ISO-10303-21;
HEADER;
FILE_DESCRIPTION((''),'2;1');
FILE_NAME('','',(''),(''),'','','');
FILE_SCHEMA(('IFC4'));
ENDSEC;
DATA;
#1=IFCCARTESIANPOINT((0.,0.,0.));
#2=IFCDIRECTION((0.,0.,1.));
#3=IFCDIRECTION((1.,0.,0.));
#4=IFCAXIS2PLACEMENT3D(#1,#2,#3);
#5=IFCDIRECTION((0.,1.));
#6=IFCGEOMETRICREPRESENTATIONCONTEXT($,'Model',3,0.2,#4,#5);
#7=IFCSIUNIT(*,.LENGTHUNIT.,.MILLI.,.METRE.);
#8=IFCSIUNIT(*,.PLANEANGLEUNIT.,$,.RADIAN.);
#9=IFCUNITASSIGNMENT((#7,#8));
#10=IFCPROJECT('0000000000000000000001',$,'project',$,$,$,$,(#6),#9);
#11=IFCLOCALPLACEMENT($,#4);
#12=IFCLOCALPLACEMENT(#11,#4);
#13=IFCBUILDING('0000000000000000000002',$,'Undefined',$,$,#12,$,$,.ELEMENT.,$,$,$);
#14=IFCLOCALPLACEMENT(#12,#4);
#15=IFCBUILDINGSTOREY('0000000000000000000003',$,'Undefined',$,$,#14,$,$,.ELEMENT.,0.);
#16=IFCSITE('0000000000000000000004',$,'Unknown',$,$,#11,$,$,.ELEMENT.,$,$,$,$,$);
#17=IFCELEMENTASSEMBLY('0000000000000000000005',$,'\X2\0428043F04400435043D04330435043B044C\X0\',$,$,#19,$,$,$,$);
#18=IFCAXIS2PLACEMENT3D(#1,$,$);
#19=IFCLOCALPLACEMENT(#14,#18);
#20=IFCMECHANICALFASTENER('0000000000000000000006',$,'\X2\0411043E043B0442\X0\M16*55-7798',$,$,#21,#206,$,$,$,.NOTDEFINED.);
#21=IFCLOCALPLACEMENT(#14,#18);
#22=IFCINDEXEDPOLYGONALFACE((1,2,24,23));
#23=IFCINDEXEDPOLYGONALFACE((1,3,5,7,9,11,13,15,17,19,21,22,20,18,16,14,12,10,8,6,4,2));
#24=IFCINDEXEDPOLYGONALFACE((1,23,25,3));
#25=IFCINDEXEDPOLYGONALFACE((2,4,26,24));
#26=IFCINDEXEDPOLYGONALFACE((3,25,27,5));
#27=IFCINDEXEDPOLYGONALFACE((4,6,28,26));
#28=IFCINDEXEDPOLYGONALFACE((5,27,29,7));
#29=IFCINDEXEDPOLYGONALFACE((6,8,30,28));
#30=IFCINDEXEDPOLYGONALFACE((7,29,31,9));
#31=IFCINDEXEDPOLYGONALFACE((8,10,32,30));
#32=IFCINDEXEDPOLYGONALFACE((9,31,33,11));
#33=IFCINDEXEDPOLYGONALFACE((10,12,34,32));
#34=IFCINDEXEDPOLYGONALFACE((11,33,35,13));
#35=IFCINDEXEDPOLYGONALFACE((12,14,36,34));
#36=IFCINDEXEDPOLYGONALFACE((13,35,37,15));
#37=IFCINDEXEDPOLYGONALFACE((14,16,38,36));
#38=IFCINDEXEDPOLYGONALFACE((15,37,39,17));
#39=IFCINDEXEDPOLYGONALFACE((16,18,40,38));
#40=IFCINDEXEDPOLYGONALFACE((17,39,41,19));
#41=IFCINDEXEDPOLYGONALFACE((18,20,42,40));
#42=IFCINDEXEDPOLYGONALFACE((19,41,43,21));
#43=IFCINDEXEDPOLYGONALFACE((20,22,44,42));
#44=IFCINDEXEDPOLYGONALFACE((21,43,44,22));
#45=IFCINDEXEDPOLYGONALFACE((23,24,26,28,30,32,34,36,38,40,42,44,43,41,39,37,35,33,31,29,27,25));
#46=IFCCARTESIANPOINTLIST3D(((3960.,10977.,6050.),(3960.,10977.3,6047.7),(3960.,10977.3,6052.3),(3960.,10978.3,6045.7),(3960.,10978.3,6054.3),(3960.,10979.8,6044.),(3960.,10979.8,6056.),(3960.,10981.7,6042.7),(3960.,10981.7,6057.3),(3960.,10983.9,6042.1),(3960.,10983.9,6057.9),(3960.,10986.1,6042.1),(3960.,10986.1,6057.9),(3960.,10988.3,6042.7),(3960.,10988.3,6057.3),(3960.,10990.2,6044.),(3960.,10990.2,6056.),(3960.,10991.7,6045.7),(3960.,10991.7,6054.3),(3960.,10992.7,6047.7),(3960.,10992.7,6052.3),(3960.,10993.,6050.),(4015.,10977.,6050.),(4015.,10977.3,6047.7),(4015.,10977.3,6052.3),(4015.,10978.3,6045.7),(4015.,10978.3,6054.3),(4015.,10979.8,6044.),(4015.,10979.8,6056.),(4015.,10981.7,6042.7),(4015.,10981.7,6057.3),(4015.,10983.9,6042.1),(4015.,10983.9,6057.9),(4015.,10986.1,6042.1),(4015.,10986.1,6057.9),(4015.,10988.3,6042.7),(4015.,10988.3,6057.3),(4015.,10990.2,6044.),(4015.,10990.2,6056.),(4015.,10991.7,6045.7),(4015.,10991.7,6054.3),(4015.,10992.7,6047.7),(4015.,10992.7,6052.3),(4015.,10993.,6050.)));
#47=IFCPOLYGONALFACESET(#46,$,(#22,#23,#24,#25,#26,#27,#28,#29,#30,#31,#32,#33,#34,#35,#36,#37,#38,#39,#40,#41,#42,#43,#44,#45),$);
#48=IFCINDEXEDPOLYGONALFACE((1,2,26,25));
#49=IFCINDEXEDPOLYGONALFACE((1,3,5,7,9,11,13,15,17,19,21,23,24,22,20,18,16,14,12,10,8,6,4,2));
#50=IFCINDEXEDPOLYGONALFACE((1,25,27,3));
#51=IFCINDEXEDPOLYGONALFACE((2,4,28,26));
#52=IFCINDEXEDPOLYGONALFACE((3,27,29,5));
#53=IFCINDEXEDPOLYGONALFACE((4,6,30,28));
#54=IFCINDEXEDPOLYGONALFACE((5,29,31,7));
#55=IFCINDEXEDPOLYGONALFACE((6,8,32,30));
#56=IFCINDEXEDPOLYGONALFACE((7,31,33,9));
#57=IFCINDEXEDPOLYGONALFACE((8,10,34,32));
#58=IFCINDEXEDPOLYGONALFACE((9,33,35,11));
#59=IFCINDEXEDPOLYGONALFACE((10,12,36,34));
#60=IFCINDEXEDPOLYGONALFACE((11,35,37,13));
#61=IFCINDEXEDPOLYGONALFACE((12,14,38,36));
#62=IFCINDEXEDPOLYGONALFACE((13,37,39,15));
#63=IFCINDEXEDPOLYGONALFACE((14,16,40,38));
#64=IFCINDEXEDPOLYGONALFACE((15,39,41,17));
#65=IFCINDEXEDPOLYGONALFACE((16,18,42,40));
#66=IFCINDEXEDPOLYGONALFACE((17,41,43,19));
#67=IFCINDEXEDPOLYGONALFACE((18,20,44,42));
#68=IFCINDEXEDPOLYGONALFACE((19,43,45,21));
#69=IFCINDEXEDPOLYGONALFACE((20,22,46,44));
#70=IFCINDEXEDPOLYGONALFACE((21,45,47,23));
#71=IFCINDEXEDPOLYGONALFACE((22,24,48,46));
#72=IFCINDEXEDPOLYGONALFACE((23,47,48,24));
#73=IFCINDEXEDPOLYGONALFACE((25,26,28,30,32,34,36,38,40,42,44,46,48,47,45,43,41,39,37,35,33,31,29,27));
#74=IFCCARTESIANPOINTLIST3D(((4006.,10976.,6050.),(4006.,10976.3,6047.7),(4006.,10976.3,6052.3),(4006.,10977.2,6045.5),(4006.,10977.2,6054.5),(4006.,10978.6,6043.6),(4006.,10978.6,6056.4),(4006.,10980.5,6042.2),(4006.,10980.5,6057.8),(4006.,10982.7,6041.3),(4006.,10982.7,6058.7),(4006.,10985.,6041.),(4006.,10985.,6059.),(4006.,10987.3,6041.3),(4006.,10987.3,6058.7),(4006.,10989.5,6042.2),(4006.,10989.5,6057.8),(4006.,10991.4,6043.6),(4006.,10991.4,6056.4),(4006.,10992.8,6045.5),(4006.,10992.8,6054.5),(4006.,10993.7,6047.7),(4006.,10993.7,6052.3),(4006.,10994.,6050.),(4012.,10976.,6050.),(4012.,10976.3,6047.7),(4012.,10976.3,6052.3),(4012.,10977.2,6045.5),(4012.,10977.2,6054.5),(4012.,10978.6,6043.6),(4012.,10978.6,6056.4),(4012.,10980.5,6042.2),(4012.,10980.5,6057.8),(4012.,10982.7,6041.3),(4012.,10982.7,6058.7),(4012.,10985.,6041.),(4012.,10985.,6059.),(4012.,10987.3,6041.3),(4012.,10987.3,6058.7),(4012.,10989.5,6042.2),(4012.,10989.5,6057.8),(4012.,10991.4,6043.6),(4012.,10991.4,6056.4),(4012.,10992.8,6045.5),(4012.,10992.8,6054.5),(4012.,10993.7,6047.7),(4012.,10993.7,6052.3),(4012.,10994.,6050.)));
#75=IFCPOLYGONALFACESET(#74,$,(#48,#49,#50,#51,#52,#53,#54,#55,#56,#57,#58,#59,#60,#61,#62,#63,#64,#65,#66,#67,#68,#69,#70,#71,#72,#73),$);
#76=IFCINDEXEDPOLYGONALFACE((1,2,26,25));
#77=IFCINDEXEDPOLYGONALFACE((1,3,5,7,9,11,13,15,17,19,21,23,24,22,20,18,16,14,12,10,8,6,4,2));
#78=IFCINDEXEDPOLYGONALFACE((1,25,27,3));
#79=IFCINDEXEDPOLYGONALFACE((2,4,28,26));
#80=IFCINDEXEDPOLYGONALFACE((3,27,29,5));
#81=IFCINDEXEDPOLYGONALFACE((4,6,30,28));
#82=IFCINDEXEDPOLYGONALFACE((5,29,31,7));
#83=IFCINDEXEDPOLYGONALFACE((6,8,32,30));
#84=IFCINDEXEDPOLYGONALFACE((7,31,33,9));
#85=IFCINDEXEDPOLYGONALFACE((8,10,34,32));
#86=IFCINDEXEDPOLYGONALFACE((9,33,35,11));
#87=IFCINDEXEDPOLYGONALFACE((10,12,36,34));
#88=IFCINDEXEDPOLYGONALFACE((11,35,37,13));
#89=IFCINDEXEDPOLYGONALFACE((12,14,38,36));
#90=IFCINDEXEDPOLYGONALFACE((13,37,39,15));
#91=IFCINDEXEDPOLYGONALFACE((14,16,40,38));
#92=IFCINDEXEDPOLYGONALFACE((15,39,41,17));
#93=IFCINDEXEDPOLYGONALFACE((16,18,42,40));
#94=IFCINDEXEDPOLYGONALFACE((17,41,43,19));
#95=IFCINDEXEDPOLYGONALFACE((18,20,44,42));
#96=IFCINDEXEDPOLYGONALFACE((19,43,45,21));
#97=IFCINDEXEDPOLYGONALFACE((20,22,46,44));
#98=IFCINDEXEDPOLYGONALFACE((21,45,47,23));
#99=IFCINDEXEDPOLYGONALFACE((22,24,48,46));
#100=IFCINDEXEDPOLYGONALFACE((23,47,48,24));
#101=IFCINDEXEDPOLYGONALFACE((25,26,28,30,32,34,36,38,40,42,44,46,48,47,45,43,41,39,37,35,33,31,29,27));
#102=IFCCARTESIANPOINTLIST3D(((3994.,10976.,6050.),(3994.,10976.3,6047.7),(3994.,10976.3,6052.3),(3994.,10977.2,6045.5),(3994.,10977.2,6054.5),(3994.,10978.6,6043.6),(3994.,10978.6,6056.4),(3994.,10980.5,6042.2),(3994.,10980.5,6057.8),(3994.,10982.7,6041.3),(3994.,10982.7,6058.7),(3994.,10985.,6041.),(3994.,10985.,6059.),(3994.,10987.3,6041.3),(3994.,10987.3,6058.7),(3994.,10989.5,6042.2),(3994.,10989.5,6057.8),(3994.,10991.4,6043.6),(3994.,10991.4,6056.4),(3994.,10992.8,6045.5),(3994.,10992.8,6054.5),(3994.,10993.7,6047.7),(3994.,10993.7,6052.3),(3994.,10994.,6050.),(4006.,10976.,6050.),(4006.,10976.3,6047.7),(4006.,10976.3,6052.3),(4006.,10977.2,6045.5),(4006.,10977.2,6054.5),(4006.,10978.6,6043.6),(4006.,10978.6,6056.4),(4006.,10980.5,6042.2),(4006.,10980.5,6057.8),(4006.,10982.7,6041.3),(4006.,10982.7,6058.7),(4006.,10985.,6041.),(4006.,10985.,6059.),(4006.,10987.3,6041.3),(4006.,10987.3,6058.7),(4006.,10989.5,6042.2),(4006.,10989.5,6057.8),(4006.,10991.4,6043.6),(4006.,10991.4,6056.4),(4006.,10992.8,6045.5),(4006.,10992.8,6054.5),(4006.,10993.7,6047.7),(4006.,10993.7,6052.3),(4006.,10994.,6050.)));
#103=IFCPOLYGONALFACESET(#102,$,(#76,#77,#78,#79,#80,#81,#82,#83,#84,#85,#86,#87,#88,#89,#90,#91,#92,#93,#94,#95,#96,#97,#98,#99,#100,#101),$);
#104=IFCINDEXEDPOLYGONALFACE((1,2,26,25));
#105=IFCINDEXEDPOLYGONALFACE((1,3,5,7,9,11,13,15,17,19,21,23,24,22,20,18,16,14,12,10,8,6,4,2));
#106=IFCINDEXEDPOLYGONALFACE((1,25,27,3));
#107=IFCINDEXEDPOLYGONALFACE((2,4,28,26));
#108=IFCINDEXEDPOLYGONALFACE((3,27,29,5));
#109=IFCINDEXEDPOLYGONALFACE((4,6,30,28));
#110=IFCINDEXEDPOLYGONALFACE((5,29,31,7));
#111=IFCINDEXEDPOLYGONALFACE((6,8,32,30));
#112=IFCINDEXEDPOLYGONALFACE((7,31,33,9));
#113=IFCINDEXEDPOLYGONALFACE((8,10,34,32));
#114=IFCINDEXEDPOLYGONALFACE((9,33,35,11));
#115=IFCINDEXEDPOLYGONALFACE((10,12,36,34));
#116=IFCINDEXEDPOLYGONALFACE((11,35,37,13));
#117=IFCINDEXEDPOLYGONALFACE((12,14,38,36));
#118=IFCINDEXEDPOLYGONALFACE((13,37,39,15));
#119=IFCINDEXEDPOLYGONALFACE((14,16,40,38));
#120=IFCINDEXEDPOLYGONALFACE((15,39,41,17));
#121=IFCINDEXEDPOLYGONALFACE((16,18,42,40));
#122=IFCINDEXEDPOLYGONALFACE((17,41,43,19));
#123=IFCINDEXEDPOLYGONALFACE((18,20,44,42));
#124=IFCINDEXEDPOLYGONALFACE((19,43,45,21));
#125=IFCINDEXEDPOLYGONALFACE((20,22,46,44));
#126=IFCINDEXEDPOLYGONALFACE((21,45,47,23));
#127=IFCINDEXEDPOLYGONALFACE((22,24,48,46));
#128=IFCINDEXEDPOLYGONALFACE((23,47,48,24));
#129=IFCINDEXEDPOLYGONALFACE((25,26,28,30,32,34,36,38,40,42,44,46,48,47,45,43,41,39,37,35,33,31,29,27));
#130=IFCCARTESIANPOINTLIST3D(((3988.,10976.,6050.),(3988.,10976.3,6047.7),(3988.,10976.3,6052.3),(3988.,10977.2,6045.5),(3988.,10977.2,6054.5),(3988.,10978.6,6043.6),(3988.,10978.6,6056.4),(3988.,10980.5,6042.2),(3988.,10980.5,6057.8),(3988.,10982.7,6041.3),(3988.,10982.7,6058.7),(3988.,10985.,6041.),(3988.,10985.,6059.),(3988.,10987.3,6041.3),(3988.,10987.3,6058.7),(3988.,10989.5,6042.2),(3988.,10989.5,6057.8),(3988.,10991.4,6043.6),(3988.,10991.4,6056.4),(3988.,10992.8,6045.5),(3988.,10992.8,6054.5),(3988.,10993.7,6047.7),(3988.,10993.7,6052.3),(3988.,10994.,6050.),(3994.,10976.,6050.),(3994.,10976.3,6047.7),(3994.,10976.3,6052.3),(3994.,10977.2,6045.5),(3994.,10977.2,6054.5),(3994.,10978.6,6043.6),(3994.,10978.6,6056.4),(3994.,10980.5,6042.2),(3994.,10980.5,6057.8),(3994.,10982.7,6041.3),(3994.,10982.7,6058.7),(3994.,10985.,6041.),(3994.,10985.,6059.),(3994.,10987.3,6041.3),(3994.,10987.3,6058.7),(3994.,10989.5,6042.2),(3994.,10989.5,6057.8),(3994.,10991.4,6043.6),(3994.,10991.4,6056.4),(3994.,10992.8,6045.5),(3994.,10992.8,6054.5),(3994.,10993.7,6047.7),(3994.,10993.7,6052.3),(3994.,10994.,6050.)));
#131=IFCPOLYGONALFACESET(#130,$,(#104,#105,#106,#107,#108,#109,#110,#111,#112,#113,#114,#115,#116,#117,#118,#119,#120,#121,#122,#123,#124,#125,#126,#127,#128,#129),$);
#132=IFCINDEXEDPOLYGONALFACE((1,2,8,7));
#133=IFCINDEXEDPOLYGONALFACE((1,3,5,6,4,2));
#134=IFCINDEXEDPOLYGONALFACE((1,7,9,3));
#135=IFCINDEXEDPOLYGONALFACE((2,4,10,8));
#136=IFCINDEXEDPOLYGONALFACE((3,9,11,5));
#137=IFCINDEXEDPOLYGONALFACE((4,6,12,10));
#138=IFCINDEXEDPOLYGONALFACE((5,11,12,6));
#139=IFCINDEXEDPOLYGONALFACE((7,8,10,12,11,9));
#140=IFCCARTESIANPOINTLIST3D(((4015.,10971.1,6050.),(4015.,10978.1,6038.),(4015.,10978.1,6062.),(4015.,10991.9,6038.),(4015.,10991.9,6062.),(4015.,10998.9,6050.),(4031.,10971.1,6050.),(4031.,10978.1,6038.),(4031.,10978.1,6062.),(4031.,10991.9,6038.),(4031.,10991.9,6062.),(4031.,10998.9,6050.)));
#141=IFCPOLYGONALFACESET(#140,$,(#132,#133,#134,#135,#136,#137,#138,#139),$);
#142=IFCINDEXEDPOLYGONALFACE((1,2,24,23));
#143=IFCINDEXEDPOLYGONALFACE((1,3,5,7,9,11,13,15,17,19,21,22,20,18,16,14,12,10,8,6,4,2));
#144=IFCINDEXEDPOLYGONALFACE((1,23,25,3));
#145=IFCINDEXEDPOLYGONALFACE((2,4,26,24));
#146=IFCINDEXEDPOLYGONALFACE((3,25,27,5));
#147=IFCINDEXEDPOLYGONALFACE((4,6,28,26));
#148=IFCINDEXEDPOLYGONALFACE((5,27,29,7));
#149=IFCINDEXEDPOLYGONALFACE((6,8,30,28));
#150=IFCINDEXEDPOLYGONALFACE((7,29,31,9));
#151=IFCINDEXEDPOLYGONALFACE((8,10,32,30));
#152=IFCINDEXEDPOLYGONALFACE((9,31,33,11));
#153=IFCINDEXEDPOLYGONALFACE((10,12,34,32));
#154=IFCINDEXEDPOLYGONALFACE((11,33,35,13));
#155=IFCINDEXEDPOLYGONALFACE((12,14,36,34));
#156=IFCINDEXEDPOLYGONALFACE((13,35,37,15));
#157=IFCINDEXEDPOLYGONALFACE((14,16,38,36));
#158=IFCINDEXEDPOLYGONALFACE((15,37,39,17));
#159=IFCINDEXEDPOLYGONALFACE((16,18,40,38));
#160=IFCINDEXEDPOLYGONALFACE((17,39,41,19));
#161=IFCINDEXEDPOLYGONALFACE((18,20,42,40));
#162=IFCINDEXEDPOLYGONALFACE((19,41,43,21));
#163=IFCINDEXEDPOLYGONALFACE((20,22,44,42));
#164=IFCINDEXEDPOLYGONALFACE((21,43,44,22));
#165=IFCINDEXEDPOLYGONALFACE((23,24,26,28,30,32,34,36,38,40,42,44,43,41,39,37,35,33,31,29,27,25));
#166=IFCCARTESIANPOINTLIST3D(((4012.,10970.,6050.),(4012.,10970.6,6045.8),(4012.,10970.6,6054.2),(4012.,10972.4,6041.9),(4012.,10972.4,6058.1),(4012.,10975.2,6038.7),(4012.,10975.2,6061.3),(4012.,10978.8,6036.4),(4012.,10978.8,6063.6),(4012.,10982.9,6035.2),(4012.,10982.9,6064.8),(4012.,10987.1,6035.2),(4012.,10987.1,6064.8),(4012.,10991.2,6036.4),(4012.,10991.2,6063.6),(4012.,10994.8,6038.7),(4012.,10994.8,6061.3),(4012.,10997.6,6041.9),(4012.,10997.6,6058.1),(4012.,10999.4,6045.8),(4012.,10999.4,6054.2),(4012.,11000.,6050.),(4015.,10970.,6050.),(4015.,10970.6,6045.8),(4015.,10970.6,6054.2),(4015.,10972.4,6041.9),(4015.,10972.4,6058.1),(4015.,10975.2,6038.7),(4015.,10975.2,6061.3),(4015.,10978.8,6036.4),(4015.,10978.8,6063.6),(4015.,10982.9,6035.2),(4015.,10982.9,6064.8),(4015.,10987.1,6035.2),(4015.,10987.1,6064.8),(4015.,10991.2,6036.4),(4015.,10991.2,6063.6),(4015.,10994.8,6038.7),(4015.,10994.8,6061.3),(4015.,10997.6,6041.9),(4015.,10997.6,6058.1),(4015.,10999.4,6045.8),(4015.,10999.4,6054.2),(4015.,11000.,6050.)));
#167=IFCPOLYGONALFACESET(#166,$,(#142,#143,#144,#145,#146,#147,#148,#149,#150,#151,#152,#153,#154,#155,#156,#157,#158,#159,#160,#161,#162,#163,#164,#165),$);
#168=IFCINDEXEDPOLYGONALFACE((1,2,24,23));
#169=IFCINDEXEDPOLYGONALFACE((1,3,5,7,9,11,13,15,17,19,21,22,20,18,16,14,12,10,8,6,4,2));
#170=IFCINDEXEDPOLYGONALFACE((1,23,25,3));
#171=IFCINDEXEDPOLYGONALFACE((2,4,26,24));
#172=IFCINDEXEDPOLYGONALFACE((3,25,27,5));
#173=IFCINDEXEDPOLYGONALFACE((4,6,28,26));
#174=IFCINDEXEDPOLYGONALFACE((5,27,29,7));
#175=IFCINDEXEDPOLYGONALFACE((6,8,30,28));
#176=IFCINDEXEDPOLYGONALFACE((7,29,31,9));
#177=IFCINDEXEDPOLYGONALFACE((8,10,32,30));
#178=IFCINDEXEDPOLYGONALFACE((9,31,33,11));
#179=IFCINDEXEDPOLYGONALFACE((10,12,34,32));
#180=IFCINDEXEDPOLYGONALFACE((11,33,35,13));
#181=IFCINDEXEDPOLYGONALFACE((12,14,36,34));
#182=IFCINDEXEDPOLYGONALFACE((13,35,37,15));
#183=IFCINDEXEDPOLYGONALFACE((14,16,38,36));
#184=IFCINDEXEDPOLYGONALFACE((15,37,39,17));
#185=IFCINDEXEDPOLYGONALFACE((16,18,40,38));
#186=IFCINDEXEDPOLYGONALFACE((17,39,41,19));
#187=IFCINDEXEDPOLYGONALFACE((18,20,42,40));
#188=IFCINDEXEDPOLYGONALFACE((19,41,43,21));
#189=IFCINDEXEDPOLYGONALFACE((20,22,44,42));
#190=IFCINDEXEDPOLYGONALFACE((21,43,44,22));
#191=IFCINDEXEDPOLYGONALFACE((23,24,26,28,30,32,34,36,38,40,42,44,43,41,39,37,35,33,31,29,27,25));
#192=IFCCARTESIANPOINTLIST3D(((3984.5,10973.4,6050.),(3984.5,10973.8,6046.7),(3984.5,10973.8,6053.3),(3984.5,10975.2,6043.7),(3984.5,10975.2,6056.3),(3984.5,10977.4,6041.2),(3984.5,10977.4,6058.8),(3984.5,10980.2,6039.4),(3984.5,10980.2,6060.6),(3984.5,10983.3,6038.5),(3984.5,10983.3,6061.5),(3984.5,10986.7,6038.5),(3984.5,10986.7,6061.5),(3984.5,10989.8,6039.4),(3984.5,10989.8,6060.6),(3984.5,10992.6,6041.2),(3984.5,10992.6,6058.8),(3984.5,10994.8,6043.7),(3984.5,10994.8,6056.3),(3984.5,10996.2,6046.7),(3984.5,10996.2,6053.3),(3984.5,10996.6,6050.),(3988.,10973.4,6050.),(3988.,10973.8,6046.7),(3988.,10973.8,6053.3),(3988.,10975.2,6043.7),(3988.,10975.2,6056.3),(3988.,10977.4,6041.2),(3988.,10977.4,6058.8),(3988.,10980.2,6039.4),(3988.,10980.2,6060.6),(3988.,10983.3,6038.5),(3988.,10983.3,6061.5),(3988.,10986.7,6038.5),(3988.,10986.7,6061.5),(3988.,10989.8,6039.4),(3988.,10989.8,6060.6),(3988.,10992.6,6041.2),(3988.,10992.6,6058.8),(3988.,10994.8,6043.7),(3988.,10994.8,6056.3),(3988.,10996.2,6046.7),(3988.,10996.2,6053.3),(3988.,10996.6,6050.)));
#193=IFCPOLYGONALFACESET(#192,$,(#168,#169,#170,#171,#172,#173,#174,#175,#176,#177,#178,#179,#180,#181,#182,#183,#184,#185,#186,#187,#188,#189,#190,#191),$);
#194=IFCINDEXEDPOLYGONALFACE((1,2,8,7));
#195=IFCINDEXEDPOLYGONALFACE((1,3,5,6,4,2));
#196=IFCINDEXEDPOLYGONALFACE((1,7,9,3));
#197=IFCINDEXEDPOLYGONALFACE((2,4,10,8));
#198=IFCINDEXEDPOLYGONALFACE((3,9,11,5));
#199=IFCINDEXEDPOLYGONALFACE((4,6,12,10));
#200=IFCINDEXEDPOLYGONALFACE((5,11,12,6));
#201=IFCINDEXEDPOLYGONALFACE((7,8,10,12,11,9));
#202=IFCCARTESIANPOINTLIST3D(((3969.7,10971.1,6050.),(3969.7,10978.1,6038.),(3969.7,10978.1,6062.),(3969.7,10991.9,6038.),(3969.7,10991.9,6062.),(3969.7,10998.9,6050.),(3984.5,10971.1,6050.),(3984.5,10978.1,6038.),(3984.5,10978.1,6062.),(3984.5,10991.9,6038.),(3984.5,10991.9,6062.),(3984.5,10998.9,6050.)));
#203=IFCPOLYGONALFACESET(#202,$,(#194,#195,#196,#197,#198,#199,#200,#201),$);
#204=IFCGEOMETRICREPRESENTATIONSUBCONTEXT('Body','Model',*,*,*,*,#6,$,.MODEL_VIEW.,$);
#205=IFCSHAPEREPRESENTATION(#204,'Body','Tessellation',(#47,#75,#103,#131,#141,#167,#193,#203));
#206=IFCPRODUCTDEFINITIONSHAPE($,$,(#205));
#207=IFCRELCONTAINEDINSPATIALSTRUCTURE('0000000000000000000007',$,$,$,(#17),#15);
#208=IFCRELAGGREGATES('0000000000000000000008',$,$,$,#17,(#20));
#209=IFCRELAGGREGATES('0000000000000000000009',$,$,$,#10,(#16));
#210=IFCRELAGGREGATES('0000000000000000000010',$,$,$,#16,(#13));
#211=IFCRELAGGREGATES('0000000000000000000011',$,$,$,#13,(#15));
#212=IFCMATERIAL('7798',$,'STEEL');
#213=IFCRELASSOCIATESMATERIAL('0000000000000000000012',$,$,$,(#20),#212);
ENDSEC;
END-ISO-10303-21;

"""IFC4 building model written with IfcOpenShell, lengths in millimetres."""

from ifc_helpers import new_model, si_unit, direction, frame, origin_with_axes, place, context, subcontext, project, spatial, line, arc, indexed_curve, outline, extrude, source, transform, mapped, material, element, aggregate, save


model = new_model("IFC4")

# Units and contexts
model_context = context("Model", 3, precision=0.2, world=origin_with_axes(), true_north=direction((0.0, 1.0)))
body_context = subcontext(model_context, "Body", "Model", "MODEL_VIEW")
ifc_project = project(units=[si_unit("LENGTHUNIT", "METRE", prefix="MILLI"), si_unit("PLANEANGLEUNIT", "RADIAN")], contexts=[model_context])

# Site, building, storey
site_placement = place(None, origin_with_axes())
site = spatial("IfcSite", under=ifc_project, at=site_placement, Name="Unknown", CompositionType="ELEMENT")
building_placement = place(site_placement, origin_with_axes())
building = spatial("IfcBuilding", under=site, at=building_placement, Name="Undefined", CompositionType="ELEMENT")
storey_placement = place(building_placement, origin_with_axes())
storey = spatial("IfcBuildingStorey", under=building, at=storey_placement, Name="Undefined", CompositionType="ELEMENT", Elevation=0.0)

# Shared definitions
ifc_material_1 = material(Name="7798", Category="STEEL")

# Element assembly, mechanical fastener
assembly_1_placement = place(storey_placement, frame((3949.0, 5673.0, 6045.0), z_axis=(0.0, 0.0, 1.0), x_axis=(0.0, 1.0, 0.0)))
assembly_1 = element("IfcElementAssembly", 1, at=assembly_1_placement, inside=storey, Name="Шпренгель")
shared_shape_1 = source(origin_with_axes(), body_context, "Body", "SweptSolid", [
    extrude(outline(indexed_curve([(8.0, 0.0), (0.0, 8.0), (-8.0, 0.0), (0.0, -8.0)], segments=[arc(1, 2, 3), arc(3, 4, 1)])), frame((0.0, 0.0, 15.0), z_axis=(0.0, 0.0, -1.0), x_axis=(0.0, 1.0, 0.0)), (0.0, 0.0, 1.0), 55.0),
    extrude(outline(indexed_curve([(0.0, 9.0), (6.4, 6.4), (9.0, 0.0), (6.4, -6.4), (0.0, -9.0), (-0.8, -9.0), (-9.0, 0.0), (-6.4, 6.4)], segments=[arc(1, 2, 3), arc(3, 4, 5), arc(5, 6, 7), arc(7, 8, 1)])), frame((0.0, 0.0, 12.0), z_axis=(0.0, 0.0, -1.0), x_axis=(0.0, 1.0, 0.0)), (0.0, 0.0, 1.0), 6.0),
    extrude(outline(indexed_curve([(0.0, 9.0), (6.4, 6.4), (9.0, 0.0), (6.4, -6.4), (0.0, -9.0), (-0.8, -9.0), (-9.0, 0.0), (-6.4, 6.4)], segments=[arc(1, 2, 3), arc(3, 4, 5), arc(5, 6, 7), arc(7, 8, 1)])), frame((0.0, 0.0, 6.0), z_axis=(0.0, 0.0, -1.0), x_axis=(0.0, 1.0, 0.0)), (0.0, 0.0, 1.0), 12.0),
    extrude(outline(indexed_curve([(0.0, 9.0), (6.4, 6.4), (9.0, 0.0), (6.4, -6.4), (0.0, -9.0), (-0.8, -9.0), (-9.0, 0.0), (-6.4, 6.4)], segments=[arc(1, 2, 3), arc(3, 4, 5), arc(5, 6, 7), arc(7, 8, 1)])), frame((0.0, 0.0, -6.0), z_axis=(0.0, 0.0, -1.0), x_axis=(0.0, 1.0, 0.0)), (0.0, 0.0, 1.0), 6.0),
    extrude(outline(indexed_curve([(13.9, 0.0), (6.9, 12.0), (-6.9, 12.0), (-13.9, 0.0), (-6.9, -12.0), (6.9, -12.0)], segments=[line(1, 2, 3, 4, 5, 6, 1)])), frame((0.0, 0.0, 31.0), z_axis=(0.0, 0.0, -1.0), x_axis=(0.0, 1.0, 0.0)), (0.0, 0.0, 1.0), 16.0),
    extrude(outline(indexed_curve([(15.0, 0.0), (0.0, 15.0), (-15.0, 0.0), (0.0, -15.0)], segments=[arc(1, 2, 3), arc(3, 4, 1)])), frame((0.0, 0.0, 15.0), z_axis=(0.0, 0.0, -1.0), x_axis=(0.0, 1.0, 0.0)), (0.0, 0.0, 1.0), 3.0),
    extrude(outline(indexed_curve([(11.7, 0.0), (0.0, 11.7), (-11.7, 0.0), (0.0, -11.7)], segments=[arc(1, 2, 3), arc(3, 4, 1)])), frame((0.0, 0.0, -12.0), z_axis=(0.0, 0.0, -1.0), x_axis=(0.0, 1.0, 0.0)), (0.0, 0.0, 1.0), 3.5),
    extrude(outline(indexed_curve([(13.9, 0.0), (6.9, 12.0), (-6.9, 12.0), (-13.9, 0.0), (-6.9, -12.0), (6.9, -12.0)], segments=[line(1, 2, 3, 4, 5, 6, 1)])), frame((0.0, 0.0, -15.5), z_axis=(0.0, 0.0, -1.0), x_axis=(0.0, 1.0, 0.0)), (0.0, 0.0, 1.0), 14.8),
])
mechanical_fastener_1_placement = place(assembly_1_placement, frame((5312.0, -51.0, 5.0), z_axis=(0.0, -1.0, 0.0), x_axis=(0.0, 0.0, 1.0)))
mechanical_fastener_1 = element("IfcMechanicalFastener", 2, at=mechanical_fastener_1_placement, material=ifc_material_1, Name="БолтM16*55-7798", PredefinedType="NOTDEFINED", context=body_context, shape_type="MappedRepresentation", body=[
    mapped(shared_shape_1, transform((0.0, 0.0, 0.0))),
])
aggregate(assembly_1, [mechanical_fastener_1])

save(model, "model.ifc")
